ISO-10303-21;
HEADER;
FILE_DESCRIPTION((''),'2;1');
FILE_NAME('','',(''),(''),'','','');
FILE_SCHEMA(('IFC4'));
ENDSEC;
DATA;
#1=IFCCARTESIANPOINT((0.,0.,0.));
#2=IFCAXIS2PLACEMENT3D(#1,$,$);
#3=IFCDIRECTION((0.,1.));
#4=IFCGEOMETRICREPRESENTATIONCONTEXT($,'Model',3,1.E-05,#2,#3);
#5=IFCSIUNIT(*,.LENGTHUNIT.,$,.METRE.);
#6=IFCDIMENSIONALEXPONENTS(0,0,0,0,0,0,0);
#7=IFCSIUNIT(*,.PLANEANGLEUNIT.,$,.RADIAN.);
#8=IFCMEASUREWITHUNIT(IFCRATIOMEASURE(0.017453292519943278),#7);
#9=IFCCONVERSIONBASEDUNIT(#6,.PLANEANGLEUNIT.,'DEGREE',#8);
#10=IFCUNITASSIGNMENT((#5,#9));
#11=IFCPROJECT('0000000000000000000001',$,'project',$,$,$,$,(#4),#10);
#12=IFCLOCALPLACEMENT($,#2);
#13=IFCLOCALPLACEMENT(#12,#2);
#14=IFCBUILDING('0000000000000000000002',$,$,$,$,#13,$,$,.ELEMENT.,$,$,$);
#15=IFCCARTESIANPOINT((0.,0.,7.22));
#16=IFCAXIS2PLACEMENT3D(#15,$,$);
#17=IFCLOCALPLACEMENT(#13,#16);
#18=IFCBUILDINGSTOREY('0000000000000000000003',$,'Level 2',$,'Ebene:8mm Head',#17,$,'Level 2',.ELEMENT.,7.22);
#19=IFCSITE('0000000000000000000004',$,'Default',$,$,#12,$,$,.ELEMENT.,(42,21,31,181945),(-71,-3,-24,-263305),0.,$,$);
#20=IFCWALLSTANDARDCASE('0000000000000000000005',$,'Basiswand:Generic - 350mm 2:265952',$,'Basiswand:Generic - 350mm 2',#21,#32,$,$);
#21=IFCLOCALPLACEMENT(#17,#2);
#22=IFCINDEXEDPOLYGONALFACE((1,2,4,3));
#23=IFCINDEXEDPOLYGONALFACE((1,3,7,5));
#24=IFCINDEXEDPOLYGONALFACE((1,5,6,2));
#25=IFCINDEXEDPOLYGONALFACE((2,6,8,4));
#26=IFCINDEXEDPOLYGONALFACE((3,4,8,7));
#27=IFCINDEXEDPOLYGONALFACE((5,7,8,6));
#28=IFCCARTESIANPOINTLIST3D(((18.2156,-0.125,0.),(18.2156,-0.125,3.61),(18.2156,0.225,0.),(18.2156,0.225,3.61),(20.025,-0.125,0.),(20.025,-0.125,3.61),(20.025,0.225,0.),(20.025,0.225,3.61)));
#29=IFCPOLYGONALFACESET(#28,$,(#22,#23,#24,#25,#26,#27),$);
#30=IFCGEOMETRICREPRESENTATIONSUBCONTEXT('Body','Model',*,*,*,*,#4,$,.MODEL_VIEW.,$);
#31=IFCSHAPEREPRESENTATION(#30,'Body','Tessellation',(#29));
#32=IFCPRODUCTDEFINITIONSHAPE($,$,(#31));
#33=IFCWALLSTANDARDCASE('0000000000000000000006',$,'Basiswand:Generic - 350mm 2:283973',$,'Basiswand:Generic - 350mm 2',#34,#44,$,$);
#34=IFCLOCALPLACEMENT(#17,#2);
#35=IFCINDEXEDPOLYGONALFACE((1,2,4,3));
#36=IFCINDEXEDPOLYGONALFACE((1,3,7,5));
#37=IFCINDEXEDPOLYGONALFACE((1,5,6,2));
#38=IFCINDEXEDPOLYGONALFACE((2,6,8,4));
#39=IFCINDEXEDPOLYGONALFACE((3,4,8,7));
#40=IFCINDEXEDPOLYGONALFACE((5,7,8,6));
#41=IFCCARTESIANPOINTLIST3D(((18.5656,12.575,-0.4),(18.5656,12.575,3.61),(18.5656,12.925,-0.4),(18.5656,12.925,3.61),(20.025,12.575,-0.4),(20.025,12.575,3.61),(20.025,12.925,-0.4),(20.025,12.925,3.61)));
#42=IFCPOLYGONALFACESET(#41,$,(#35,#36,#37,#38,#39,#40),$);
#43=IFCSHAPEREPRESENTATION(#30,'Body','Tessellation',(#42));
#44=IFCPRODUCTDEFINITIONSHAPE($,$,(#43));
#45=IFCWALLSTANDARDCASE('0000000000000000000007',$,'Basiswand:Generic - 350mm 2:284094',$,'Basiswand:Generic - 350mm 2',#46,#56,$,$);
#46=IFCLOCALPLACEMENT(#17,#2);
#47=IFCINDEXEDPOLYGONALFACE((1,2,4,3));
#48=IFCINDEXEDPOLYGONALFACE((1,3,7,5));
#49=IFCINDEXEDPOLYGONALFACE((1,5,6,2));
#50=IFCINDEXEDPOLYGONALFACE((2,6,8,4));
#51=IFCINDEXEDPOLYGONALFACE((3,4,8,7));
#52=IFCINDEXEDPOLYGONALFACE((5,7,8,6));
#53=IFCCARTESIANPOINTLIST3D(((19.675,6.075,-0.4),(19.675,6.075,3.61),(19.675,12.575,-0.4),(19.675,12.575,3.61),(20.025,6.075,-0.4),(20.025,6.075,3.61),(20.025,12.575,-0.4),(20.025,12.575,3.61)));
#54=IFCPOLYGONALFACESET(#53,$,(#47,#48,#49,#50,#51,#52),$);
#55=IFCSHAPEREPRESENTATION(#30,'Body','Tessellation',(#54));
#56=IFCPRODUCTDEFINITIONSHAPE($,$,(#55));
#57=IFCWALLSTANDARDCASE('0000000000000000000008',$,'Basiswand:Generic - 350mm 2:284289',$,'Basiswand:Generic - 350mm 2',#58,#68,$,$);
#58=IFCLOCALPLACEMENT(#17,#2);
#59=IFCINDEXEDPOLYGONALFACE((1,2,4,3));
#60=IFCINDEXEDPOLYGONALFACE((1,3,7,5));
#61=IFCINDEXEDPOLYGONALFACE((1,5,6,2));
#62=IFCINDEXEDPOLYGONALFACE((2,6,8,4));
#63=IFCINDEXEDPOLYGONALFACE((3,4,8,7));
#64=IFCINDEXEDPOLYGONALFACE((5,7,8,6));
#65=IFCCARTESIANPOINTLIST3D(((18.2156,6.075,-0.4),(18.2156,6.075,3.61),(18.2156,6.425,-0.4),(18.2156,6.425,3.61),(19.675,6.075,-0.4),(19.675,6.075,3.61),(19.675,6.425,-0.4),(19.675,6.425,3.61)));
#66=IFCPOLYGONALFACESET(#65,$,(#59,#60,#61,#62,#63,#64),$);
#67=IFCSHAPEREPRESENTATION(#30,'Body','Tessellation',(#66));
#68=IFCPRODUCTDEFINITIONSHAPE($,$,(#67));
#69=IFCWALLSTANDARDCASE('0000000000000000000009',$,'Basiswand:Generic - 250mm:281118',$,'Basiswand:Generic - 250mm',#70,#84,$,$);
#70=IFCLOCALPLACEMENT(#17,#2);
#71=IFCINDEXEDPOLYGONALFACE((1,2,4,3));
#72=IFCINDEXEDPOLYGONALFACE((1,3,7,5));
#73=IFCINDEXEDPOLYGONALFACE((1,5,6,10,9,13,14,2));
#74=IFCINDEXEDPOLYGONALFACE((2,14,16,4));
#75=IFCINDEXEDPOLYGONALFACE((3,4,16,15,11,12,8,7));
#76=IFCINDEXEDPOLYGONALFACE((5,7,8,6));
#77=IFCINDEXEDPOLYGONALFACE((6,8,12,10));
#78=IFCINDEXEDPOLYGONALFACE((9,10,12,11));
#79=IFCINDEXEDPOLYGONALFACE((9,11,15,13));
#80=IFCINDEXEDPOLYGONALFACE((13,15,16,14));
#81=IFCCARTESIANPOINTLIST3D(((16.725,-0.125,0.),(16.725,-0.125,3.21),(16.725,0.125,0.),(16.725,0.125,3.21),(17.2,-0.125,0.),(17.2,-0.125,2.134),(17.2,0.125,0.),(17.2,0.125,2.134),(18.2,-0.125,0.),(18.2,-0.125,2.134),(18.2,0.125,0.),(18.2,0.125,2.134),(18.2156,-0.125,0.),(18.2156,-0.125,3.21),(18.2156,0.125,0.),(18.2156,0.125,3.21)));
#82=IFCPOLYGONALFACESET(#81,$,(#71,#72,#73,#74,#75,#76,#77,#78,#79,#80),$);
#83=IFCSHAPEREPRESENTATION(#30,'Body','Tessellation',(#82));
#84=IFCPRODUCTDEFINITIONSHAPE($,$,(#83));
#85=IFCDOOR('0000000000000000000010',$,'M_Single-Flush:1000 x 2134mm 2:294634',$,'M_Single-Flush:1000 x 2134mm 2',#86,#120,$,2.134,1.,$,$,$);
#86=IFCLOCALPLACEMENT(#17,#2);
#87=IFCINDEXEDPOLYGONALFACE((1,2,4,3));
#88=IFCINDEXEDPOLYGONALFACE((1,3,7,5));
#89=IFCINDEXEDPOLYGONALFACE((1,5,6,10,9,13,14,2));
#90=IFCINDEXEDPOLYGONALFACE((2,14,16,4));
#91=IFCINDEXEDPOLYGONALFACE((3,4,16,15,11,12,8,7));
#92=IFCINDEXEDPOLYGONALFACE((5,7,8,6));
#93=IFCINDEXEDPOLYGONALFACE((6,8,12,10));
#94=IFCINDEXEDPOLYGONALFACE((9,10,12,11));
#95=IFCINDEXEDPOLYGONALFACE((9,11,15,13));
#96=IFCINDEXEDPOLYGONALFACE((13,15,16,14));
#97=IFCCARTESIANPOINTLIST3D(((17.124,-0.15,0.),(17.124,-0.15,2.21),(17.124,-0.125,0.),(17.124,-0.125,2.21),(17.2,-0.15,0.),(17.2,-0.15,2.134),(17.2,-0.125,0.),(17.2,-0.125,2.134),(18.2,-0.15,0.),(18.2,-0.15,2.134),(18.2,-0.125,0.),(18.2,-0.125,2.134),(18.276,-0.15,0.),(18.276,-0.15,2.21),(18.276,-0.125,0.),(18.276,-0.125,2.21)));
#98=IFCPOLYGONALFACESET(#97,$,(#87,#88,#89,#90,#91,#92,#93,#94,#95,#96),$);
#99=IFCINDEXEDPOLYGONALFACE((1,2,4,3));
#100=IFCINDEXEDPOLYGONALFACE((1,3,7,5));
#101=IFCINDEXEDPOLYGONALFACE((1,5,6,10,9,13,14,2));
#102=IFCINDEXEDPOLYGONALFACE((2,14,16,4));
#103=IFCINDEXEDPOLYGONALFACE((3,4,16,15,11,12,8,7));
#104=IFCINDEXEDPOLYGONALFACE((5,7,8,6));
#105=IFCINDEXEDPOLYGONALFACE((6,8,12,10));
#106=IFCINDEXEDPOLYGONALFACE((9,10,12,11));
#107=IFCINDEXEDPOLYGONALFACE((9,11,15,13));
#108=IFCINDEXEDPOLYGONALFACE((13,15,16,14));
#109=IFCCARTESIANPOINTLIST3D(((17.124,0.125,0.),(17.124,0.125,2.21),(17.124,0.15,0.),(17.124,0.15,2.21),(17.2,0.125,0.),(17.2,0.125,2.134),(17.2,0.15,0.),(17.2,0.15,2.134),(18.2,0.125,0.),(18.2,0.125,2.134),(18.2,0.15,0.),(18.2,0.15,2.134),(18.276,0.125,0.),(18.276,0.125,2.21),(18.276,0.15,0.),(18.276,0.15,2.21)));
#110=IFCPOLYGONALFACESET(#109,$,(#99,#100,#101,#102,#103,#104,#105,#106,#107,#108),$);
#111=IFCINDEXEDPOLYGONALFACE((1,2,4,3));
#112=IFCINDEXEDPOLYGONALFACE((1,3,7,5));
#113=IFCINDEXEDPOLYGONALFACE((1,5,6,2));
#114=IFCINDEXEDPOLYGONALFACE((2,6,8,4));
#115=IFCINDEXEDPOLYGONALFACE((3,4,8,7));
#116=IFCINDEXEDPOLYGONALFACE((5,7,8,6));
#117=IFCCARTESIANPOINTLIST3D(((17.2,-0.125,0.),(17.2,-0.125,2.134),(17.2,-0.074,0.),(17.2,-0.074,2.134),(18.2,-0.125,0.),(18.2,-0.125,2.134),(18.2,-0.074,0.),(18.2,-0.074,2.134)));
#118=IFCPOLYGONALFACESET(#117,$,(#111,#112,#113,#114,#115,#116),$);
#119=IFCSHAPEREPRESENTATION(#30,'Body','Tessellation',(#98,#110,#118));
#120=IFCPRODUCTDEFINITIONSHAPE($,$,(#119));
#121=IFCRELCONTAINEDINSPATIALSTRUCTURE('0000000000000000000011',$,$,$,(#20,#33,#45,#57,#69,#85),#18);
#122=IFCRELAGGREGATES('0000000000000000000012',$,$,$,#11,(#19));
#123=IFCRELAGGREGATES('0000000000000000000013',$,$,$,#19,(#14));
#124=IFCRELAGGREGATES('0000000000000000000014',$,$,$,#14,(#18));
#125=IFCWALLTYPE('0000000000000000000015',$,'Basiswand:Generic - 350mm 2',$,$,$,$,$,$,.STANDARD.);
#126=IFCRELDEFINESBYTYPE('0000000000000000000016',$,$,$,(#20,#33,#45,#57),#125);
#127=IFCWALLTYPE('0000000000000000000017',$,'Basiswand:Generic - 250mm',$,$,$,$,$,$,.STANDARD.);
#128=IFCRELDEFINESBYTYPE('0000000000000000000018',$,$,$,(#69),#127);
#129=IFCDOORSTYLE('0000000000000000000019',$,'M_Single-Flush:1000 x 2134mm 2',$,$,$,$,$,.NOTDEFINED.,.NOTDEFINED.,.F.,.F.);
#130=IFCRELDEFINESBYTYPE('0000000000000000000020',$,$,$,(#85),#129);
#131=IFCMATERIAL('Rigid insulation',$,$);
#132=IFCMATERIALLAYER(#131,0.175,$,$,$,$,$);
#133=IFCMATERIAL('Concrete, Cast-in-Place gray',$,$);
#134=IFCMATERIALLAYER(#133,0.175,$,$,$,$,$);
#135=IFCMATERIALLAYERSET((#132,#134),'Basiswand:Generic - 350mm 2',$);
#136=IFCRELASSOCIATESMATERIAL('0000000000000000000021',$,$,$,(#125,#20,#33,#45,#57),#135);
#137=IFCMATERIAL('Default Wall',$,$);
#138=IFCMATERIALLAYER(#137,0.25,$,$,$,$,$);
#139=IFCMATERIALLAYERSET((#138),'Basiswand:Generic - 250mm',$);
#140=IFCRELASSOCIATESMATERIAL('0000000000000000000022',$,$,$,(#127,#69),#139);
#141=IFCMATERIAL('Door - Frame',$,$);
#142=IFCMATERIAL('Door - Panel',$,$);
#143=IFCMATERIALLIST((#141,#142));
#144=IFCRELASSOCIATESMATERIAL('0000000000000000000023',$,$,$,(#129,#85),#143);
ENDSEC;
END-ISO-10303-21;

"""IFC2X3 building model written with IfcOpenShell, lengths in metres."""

from ifc_helpers import new_model, entity, si_unit, converted_unit, direction, frame, frame_2d, origin, place, context, subcontext, project, spatial, polyline, rectangle, outline, extrude, source, transform, mapped, material, material_list, layer, layer_set, layer_usage, type_object, type_shapes, element, fill, save


model = new_model("IFC2X3")

# Units and contexts
model_context = context("Model", 3, precision=1e-05, world=origin(), true_north=direction((0.0, 1.0)))
body_context = subcontext(model_context, "Body", "Model", "MODEL_VIEW")
ifc_project = project(units=[si_unit("LENGTHUNIT", "METRE"), converted_unit("PLANEANGLEUNIT", "DEGREE", entity("IfcRatioMeasure", 0.017453292519943278), si_unit("PLANEANGLEUNIT", "RADIAN"), dimensions=[0, 0, 0, 0, 0, 0, 0])], contexts=[model_context])

# Site, building, storey
site_placement = place(None, origin())
site = spatial("IfcSite", under=ifc_project, at=site_placement, Name="Default", CompositionType="ELEMENT", RefLatitude=(42, 21, 31, 181945), RefLongitude=(-71, -3, -24, -263305), RefElevation=0.0)
building_placement = place(site_placement, origin())
building = spatial("IfcBuilding", under=site, at=building_placement, CompositionType="ELEMENT")
storey_placement = place(building_placement, frame((0.0, 0.0, 7.22)))
storey = spatial("IfcBuildingStorey", under=building, at=storey_placement, Name="Level 2", ObjectType="Ebene:8mm Head", LongName="Level 2", CompositionType="ELEMENT", Elevation=7.22)

# Walls
ifc_material_1 = material(Name="Rigid insulation")
ifc_layer_1 = layer(ifc_material_1, 0.175)
ifc_material_2 = material(Name="Concrete, Cast-in-Place gray")
ifc_layer_2 = layer(ifc_material_2, 0.175)
ifc_layer_set_1 = layer_set([ifc_layer_1, ifc_layer_2], Name="Basiswand:Generic - 350mm 2")
ifc_layer_usage_1 = layer_usage(ifc_layer_set_1, "AXIS2", "NEGATIVE", 0.175)
wall_type_1 = type_object("IfcWallType", Name="Basiswand:Generic - 350mm 2", PredefinedType="STANDARD", material=ifc_layer_set_1)
wall_1_placement = place(storey_placement, frame((20.025, 0.05, 0.0), z_axis=(0.0, 0.0, 1.0), x_axis=(-1.0, 0.0, 0.0)))
element("IfcWallStandardCase", 1, at=wall_1_placement, inside=storey, type_object=wall_type_1, material=ifc_layer_usage_1, Name="Basiswand:Generic - 350mm 2:265952", ObjectType="Basiswand:Generic - 350mm 2", context=body_context, shape_type="SweptSolid", body=[
    extrude(rectangle(XDim=1.8094, YDim=0.35, at=frame_2d((0.9047, 0.0), x_axis=(-1.0, 0.0))), origin(), (0.0, 0.0, 1.0), 3.61),
])
ifc_layer_usage_2 = layer_usage(ifc_layer_set_1, "AXIS2", "POSITIVE", -0.175)
wall_2_placement = place(storey_placement, frame((18.5656, 12.75, -0.4)))
element("IfcWallStandardCase", 2, at=wall_2_placement, inside=storey, type_object=wall_type_1, material=ifc_layer_usage_2, Name="Basiswand:Generic - 350mm 2:283973", ObjectType="Basiswand:Generic - 350mm 2", context=body_context, shape_type="SweptSolid", body=[
    extrude(rectangle(XDim=1.4594, YDim=0.35, at=frame_2d((0.7297, 0.0), x_axis=(-1.0, 0.0))), origin(), (0.0, 0.0, 1.0), 4.01),
])
wall_3_placement = place(storey_placement, frame((19.85, 12.575, -0.4), z_axis=(0.0, 0.0, 1.0), x_axis=(0.0, -1.0, 0.0)))
element("IfcWallStandardCase", 3, at=wall_3_placement, inside=storey, type_object=wall_type_1, material=ifc_layer_usage_2, Name="Basiswand:Generic - 350mm 2:284094", ObjectType="Basiswand:Generic - 350mm 2", context=body_context, shape_type="SweptSolid", body=[
    extrude(rectangle(XDim=6.5, YDim=0.35, at=frame_2d((3.25, 0.0), x_axis=(-1.0, 0.0))), origin(), (0.0, 0.0, 1.0), 4.01),
])

# Wall, opening
wall_4_placement = place(storey_placement, frame((19.675, 6.25, -0.4), z_axis=(0.0, 0.0, 1.0), x_axis=(-1.0, 0.0, 0.0)))
wall_4 = element("IfcWallStandardCase", 4, at=wall_4_placement, inside=storey, type_object=wall_type_1, material=ifc_layer_usage_2, Name="Basiswand:Generic - 350mm 2:284289", ObjectType="Basiswand:Generic - 350mm 2", context=body_context, shape_type="SweptSolid", body=[
    extrude(rectangle(XDim=1.4594, YDim=0.35, at=frame_2d((0.7297, 0.0), x_axis=(-1.0, 0.0))), origin(), (0.0, 0.0, 1.0), 4.01),
])
opening_1_placement = place(wall_4_placement, origin())
element("IfcOpeningElement", 5, at=opening_1_placement, cuts=wall_4, ObjectType="Opening", context=body_context, shape_type="SweptSolid", body=[
    extrude(rectangle(XDim=3.61, YDim=0.35, at=frame_2d((0.0, 0.0), x_axis=(0.0, 1.0))), frame((1.2844, 0.175, 2.205), z_axis=(0.0, 1.0, 0.0), x_axis=(1.0, 0.0, 0.0)), (0.0, 0.0, 1.0), 5.85),
])

# Wall, opening, door
ifc_material_3 = material(Name="Default Wall")
ifc_layer_3 = layer(ifc_material_3, 0.25)
ifc_layer_set_2 = layer_set([ifc_layer_3], Name="Basiswand:Generic - 250mm")
ifc_layer_usage_3 = layer_usage(ifc_layer_set_2, "AXIS2", "NEGATIVE", 0.125)
wall_type_2 = type_object("IfcWallType", Name="Basiswand:Generic - 250mm", PredefinedType="STANDARD", material=ifc_layer_set_2)
wall_5_placement = place(storey_placement, frame((16.725, 0.0, 0.0)))
wall_5 = element("IfcWallStandardCase", 6, at=wall_5_placement, inside=storey, type_object=wall_type_2, material=ifc_layer_usage_3, Name="Basiswand:Generic - 250mm:281118", ObjectType="Basiswand:Generic - 250mm", context=body_context, shape_type="SweptSolid", body=[
    extrude(rectangle(XDim=1.4906, YDim=0.25, at=frame_2d((0.7453, 0.0), x_axis=(-1.0, 0.0))), origin(), (0.0, 0.0, 1.0), 3.21),
])
opening_2_placement = place(wall_5_placement, frame((1.475, 0.125, 0.0)))
opening_2 = element("IfcOpeningElement", 7, at=opening_2_placement, cuts=wall_5, ObjectType="Opening", context=body_context, shape_type="SweptSolid", body=[
    extrude(rectangle(XDim=1.0, YDim=2.134, at=frame_2d((1.067, 0.5), x_axis=(0.0, -1.0))), frame((0.0, 0.0, 0.0), z_axis=(0.0, -1.0, 0.0), x_axis=(0.0, 0.0, 1.0)), (0.0, 0.0, 1.0), 0.25),
])
ifc_material_4 = material(Name="Door - Frame")
ifc_material_5 = material(Name="Door - Panel")
ifc_material_list_1 = material_list([ifc_material_4, ifc_material_5])
door_style_1 = type_object("IfcDoorStyle", Name="M_Single-Flush:1000 x 2134mm 2", ConstructionType="NOTDEFINED", OperationType="NOTDEFINED", ParameterTakesPrecedence=False, Sizeable=False, material=ifc_material_list_1)
shared_shape_1 = source(origin(), body_context, "Body", "SweptSolid", [
    extrude(outline(polyline([(-0.576, -1.124), (0.576, -1.124), (0.576, 1.086), (0.5, 1.086), (0.5, -1.048), (-0.5, -1.048), (-0.5, 1.086), (-0.576, 1.086), (-0.576, -1.124)])), frame((0.5, 0.275, 1.086), z_axis=(0.0, -1.0, 0.0), x_axis=(-1.0, 0.0, 0.0)), (0.0, 0.0, 1.0), 0.025),
    extrude(outline(polyline([(-1.124, -0.576), (1.086, -0.576), (1.086, -0.5), (-1.048, -0.5), (-1.048, 0.5), (1.086, 0.5), (1.086, 0.576), (-1.124, 0.576), (-1.124, -0.576)])), frame((0.5, 0.0, 1.086), z_axis=(0.0, -1.0, 0.0), x_axis=(0.0, 0.0, -1.0)), (0.0, 0.0, 1.0), 0.025),
    extrude(rectangle(XDim=1.0, YDim=0.051, at=frame_2d((0.0, 0.0), x_axis=(1.0, 0.0))), frame((0.5, 0.2245, 0.0)), (0.0, 0.0, 1.0), 2.134),
])
type_shapes(door_style_1, [shared_shape_1])
door_1_placement = place(opening_2_placement, frame((0.0, 0.0, 0.0), z_axis=(0.0, 0.0, 1.0), x_axis=(-1.0, 0.0, 0.0)))
door_1 = element("IfcDoor", 8, at=door_1_placement, inside=storey, type_object=door_style_1, material=ifc_material_list_1, Name="M_Single-Flush:1000 x 2134mm 2:294634", ObjectType="M_Single-Flush:1000 x 2134mm 2", OverallHeight=2.134, OverallWidth=1.0, context=body_context, shape_type="MappedRepresentation", body=[
    mapped(shared_shape_1, transform((0.0, 0.0, 0.0), scale=1.0)),
])
fill(opening_2, door_1)

save(model, "model.ifc")
